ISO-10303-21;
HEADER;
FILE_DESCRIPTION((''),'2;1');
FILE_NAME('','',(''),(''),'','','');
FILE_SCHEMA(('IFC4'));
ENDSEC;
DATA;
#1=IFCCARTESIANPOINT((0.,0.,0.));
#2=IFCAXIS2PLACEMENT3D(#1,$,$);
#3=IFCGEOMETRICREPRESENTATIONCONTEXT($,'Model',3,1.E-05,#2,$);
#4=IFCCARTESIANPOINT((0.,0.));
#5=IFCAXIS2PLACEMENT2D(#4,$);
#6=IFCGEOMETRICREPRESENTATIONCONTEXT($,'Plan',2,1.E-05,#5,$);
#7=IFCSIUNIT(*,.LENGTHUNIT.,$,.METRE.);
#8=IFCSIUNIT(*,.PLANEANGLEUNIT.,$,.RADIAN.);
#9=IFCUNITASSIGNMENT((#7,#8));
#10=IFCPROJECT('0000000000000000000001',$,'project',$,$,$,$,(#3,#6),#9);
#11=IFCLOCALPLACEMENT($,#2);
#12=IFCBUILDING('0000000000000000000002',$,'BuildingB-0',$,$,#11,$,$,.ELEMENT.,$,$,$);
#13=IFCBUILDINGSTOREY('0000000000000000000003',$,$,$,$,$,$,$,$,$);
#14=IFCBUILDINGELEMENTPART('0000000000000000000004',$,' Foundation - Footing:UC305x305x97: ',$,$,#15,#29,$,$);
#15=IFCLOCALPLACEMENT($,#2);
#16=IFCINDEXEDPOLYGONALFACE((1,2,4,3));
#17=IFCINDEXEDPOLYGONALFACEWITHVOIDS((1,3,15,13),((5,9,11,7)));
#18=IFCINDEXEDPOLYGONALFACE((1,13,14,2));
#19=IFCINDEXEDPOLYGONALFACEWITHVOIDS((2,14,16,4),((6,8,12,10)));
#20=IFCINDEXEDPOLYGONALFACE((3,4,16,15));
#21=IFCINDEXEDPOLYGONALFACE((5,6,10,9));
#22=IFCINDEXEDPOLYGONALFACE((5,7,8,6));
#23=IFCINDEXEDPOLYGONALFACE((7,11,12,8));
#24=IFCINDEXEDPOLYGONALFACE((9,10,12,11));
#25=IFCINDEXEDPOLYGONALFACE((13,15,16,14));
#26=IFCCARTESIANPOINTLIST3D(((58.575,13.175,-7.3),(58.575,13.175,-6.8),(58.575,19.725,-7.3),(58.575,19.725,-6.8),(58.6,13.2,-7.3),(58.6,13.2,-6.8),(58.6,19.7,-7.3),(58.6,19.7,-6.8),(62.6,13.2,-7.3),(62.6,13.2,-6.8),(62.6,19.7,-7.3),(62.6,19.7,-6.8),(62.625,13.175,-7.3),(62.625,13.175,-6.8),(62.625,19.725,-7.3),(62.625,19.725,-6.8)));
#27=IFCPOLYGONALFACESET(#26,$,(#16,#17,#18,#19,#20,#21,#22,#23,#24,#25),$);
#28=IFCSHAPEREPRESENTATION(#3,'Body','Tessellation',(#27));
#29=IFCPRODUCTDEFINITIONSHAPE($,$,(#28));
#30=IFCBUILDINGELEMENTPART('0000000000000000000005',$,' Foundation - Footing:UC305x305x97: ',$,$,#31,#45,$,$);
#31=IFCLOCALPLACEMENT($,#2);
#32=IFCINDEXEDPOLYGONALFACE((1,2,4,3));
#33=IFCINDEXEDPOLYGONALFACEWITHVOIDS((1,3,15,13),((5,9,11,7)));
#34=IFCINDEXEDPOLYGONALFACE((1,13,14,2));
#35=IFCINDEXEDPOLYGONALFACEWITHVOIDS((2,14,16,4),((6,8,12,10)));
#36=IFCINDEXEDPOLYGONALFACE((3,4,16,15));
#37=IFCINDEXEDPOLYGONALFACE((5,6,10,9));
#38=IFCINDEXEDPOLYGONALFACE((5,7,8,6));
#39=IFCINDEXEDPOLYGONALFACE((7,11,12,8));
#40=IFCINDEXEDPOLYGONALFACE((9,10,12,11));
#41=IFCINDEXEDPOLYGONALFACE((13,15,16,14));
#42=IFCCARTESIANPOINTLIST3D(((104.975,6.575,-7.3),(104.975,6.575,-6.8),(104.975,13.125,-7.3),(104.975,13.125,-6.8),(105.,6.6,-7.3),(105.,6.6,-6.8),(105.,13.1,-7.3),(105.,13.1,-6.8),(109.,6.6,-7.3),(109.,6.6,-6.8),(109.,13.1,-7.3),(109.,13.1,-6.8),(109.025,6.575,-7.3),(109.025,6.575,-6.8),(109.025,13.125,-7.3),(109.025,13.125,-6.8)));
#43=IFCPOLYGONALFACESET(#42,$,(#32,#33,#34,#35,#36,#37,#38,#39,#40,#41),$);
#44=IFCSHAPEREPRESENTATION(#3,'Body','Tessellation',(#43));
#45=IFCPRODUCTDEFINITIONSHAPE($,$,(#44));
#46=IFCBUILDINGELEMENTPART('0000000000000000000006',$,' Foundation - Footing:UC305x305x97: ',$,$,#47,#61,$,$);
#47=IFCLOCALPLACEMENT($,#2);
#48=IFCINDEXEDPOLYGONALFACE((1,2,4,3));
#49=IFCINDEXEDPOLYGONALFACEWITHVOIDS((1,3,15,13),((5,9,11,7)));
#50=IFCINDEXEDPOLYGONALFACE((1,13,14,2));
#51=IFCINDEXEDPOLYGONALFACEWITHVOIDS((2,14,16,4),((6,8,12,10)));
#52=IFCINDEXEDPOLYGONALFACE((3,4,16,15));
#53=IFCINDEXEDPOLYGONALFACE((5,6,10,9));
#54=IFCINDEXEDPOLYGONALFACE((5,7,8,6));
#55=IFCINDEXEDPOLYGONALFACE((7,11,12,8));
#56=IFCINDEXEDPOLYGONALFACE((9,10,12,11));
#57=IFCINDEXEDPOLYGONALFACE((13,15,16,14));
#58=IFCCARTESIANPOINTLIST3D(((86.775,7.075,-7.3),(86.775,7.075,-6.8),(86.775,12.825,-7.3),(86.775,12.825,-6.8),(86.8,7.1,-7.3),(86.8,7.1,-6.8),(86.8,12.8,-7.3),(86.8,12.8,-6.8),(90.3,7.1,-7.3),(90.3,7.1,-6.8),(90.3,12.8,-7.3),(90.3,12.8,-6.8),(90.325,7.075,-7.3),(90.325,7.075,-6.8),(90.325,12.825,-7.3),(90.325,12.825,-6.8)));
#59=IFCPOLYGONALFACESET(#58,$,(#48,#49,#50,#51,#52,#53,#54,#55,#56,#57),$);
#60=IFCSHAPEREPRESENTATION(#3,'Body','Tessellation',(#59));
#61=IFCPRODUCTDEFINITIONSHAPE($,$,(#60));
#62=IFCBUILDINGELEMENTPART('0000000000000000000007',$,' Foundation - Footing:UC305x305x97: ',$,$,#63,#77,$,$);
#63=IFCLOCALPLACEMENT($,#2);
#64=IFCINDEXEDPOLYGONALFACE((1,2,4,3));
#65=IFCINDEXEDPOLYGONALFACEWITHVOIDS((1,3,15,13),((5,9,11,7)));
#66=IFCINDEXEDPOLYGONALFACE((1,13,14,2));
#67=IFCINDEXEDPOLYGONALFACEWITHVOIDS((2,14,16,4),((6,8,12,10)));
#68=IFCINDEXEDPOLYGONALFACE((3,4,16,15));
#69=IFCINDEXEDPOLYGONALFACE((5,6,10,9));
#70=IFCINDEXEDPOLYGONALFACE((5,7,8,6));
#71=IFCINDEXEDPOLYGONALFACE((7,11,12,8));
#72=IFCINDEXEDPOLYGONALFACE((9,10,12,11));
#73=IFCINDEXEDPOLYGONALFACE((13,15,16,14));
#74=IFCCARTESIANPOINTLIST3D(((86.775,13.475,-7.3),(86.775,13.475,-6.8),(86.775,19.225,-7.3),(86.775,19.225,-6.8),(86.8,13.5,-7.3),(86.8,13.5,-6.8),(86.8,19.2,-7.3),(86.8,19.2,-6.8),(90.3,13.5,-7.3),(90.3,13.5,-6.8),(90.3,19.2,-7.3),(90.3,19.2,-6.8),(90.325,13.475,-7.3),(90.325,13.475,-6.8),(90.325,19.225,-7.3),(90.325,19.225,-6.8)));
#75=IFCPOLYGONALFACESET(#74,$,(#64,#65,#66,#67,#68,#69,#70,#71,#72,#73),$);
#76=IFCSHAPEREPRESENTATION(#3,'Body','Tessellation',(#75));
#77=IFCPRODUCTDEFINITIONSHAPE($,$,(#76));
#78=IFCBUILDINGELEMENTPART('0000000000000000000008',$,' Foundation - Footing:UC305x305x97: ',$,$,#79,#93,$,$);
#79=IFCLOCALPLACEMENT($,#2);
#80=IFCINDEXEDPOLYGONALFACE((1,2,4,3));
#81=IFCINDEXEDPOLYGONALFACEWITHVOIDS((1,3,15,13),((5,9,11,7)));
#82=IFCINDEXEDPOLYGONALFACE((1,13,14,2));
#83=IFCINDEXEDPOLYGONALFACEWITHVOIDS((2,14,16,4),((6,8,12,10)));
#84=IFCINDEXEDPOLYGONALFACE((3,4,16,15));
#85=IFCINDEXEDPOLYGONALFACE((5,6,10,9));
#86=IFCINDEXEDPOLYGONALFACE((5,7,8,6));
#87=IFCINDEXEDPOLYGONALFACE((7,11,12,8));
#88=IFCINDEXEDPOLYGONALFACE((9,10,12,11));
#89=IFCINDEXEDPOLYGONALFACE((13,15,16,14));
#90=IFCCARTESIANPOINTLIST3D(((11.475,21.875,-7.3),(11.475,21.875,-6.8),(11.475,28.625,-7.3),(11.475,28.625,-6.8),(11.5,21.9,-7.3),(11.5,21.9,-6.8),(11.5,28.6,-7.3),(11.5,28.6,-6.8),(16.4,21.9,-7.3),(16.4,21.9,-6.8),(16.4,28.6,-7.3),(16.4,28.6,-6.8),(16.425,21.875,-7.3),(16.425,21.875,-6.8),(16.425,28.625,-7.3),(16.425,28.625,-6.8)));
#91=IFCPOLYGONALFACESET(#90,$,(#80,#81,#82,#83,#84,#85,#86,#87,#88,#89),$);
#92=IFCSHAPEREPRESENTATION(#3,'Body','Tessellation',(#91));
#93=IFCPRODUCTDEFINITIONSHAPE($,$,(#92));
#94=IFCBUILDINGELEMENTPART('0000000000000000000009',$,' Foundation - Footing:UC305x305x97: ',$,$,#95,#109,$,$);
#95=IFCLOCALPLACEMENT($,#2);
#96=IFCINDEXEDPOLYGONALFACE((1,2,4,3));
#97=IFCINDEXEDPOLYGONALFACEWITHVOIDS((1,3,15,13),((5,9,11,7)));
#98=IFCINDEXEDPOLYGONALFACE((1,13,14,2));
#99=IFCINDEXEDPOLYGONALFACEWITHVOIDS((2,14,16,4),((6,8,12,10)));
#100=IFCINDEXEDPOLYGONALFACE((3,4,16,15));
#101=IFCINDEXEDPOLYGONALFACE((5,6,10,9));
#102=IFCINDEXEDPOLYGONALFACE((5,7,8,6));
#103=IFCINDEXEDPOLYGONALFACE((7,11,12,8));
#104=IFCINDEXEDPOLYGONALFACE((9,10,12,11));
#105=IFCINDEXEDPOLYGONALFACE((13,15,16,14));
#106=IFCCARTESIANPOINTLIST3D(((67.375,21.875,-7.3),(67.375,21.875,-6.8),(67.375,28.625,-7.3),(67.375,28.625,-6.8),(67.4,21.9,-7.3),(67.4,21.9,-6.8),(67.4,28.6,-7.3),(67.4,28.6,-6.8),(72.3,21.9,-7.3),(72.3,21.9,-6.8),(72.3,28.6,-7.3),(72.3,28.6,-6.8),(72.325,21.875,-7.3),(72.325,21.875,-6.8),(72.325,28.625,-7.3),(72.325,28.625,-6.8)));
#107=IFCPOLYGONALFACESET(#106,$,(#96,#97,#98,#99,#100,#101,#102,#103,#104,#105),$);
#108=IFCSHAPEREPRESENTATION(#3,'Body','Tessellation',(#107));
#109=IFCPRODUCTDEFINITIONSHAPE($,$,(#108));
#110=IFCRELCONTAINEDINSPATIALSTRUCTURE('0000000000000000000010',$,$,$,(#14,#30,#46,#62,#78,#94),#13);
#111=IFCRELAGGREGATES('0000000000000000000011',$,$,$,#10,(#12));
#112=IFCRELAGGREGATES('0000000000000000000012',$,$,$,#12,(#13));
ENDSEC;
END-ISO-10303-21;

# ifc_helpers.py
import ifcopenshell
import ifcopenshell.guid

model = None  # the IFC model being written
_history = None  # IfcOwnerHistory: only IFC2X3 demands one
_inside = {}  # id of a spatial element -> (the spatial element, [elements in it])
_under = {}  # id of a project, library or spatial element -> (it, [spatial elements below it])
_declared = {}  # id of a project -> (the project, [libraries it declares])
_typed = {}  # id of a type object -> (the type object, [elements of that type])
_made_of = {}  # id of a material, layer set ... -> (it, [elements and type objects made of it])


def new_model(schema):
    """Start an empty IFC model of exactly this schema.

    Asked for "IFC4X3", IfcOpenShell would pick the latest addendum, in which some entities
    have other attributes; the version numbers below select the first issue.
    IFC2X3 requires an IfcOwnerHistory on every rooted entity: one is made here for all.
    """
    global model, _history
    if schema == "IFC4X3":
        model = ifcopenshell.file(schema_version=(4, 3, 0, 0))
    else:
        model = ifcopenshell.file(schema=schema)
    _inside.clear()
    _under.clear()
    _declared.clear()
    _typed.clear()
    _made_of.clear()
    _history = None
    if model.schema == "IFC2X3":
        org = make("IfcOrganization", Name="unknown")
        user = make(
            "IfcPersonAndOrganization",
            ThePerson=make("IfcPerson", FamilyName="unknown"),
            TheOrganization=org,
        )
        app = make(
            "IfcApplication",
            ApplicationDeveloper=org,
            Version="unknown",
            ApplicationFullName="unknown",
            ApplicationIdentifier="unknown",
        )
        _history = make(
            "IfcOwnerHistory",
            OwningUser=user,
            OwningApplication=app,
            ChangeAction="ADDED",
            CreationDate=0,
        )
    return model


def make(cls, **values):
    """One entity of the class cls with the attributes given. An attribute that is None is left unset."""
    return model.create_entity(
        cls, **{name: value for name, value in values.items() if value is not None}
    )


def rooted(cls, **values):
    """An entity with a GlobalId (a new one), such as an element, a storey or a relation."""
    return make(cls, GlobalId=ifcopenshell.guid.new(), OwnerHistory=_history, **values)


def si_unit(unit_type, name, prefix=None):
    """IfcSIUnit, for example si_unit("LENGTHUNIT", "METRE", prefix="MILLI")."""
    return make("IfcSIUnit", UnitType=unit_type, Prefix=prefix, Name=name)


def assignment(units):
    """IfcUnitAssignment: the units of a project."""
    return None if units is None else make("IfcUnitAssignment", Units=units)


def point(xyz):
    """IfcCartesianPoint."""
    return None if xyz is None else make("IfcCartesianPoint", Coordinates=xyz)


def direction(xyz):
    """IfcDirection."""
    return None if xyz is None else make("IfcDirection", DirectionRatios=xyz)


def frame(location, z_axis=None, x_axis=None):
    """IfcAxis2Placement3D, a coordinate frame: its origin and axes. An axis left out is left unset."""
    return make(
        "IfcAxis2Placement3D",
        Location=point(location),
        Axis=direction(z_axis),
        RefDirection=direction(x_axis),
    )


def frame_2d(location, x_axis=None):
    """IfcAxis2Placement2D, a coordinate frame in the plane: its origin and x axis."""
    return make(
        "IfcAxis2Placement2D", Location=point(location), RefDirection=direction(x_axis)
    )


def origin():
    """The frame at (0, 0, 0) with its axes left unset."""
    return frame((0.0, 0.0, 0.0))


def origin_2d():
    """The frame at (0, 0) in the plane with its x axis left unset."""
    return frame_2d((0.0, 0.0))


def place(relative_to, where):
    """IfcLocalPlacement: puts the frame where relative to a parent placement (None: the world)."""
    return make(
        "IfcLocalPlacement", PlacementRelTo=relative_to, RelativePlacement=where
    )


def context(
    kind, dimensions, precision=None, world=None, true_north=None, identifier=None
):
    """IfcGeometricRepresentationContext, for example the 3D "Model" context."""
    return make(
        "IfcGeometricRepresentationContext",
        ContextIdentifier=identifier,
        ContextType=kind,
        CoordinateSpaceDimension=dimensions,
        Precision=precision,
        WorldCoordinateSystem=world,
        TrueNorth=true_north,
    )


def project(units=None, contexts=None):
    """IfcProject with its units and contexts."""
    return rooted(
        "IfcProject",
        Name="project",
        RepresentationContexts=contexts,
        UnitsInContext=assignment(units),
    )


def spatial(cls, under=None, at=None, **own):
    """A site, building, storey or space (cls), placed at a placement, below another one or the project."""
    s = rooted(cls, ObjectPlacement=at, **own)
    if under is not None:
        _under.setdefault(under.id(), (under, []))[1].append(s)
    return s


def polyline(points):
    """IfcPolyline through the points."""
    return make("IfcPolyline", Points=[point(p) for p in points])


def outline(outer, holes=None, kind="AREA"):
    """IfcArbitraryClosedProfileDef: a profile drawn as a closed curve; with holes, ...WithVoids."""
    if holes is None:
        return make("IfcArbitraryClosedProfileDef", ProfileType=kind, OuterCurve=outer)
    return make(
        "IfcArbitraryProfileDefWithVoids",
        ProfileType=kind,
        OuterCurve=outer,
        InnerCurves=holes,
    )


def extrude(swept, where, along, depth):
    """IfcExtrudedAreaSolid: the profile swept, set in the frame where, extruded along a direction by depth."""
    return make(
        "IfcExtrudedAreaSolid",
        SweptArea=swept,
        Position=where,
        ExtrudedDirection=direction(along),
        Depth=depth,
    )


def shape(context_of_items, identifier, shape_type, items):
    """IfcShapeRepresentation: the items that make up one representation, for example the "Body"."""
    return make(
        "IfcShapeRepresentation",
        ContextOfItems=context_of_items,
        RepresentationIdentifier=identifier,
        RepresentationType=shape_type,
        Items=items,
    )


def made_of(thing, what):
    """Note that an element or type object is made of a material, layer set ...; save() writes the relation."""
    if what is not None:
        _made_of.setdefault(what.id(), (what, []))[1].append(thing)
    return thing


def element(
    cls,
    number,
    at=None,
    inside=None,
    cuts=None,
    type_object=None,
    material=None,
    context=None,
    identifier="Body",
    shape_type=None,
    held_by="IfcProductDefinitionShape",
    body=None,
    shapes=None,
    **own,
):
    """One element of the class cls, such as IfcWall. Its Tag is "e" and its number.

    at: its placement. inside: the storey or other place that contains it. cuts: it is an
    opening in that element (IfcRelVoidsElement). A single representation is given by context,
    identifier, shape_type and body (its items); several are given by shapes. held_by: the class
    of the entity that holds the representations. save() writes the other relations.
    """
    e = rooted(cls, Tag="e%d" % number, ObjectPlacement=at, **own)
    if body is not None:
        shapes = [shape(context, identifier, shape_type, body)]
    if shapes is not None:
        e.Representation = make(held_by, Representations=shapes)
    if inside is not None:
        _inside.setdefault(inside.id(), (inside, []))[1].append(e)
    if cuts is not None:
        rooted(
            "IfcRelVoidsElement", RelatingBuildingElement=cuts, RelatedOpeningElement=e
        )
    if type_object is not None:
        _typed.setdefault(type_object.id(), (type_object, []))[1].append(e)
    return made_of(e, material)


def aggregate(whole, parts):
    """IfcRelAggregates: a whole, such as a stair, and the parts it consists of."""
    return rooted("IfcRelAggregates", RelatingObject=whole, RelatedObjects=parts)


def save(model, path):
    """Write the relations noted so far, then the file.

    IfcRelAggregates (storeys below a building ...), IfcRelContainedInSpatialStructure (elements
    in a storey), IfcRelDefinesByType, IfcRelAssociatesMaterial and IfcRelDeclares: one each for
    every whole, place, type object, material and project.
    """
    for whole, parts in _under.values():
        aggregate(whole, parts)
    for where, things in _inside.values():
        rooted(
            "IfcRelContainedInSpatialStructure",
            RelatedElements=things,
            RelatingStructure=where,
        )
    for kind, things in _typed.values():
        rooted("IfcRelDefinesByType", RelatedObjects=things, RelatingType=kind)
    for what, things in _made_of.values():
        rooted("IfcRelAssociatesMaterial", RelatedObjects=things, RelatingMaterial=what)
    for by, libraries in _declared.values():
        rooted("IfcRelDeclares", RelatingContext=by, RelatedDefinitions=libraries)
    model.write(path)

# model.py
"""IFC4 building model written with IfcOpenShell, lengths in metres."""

from ifc_helpers import new_model, si_unit, origin, origin_2d, place, context, project, spatial, polyline, outline, extrude, element, save


model = new_model("IFC4")

# Units and contexts
model_context = context("Model", 3, precision=1e-05, world=origin())
plan_context = context("Plan", 2, precision=1e-05, world=origin_2d())
ifc_project = project(units=[si_unit("LENGTHUNIT", "METRE"), si_unit("PLANEANGLEUNIT", "RADIAN")], contexts=[model_context, plan_context])

# Building, storey
building_placement = place(None, origin())
building = spatial("IfcBuilding", under=ifc_project, at=building_placement, Name="BuildingB-0", CompositionType="ELEMENT")
storey = spatial("IfcBuildingStorey", under=building)

# Building element parts, openings
building_element_part_1 = element("IfcBuildingElementPart", 1, inside=storey, Name=" Foundation - Footing:UC305x305x97: ", context=model_context, shape_type="SweptSolid", body=[
    extrude(outline(polyline([(58.575, 19.725, -7.3), (62.625, 19.725, -7.3), (62.625, 13.175, -7.3), (58.575, 13.175, -7.3), (58.575, 19.725, -7.3)])), None, (0.0, 0.0, 1.0), 0.5),
])
element("IfcOpeningElement", 2, inside=storey, cuts=building_element_part_1, context=model_context, shape_type="SweptSolid", body=[
    extrude(outline(polyline([(58.6, 19.7, -7.3), (62.6, 19.7, -7.3), (62.6, 13.2, -7.3), (58.6, 13.2, -7.3), (58.6, 19.7, -7.3)])), None, (0.0, 0.0, 1.0), 0.5),
])
building_element_part_2 = element("IfcBuildingElementPart", 3, inside=storey, Name=" Foundation - Footing:UC305x305x97: ", context=model_context, shape_type="SweptSolid", body=[
    extrude(outline(polyline([(109.025, 13.125, -7.3), (104.975, 13.125, -7.3), (104.975, 6.575, -7.3), (109.025, 6.575, -7.3), (109.025, 13.125, -7.3)])), None, (0.0, 0.0, 1.0), 0.5),
])
element("IfcOpeningElement", 4, inside=storey, cuts=building_element_part_2, context=model_context, shape_type="SweptSolid", body=[
    extrude(outline(polyline([(109.0, 13.1, -7.3), (105.0, 13.1, -7.3), (105.0, 6.6, -7.3), (109.0, 6.6, -7.3), (109.0, 13.1, -7.3)])), None, (0.0, 0.0, 1.0), 0.5),
])
building_element_part_3 = element("IfcBuildingElementPart", 5, inside=storey, Name=" Foundation - Footing:UC305x305x97: ", context=model_context, shape_type="SweptSolid", body=[
    extrude(outline(polyline([(86.775, 12.825, -7.3), (90.325, 12.825, -7.3), (90.325, 7.075, -7.3), (86.775, 7.075, -7.3), (86.775, 12.825, -7.3)])), None, (0.0, 0.0, 1.0), 0.5),
])
element("IfcOpeningElement", 6, inside=storey, cuts=building_element_part_3, context=model_context, shape_type="SweptSolid", body=[
    extrude(outline(polyline([(86.8, 12.8, -7.3), (90.3, 12.8, -7.3), (90.3, 7.1, -7.3), (86.8, 7.1, -7.3), (86.8, 12.8, -7.3)])), None, (0.0, 0.0, 1.0), 0.5),
])
building_element_part_4 = element("IfcBuildingElementPart", 7, inside=storey, Name=" Foundation - Footing:UC305x305x97: ", context=model_context, shape_type="SweptSolid", body=[
    extrude(outline(polyline([(86.775, 19.225, -7.3), (90.325, 19.225, -7.3), (90.325, 13.475, -7.3), (86.775, 13.475, -7.3), (86.775, 19.225, -7.3)])), None, (0.0, 0.0, 1.0), 0.5),
])
element("IfcOpeningElement", 8, inside=storey, cuts=building_element_part_4, context=model_context, shape_type="SweptSolid", body=[
    extrude(outline(polyline([(86.8, 19.2, -7.3), (90.3, 19.2, -7.3), (90.3, 13.5, -7.3), (86.8, 13.5, -7.3), (86.8, 19.2, -7.3)])), None, (0.0, 0.0, 1.0), 0.5),
])
building_element_part_5 = element("IfcBuildingElementPart", 9, inside=storey, Name=" Foundation - Footing:UC305x305x97: ", context=model_context, shape_type="SweptSolid", body=[
    extrude(outline(polyline([(16.425, 21.875, -7.3), (16.425, 28.625, -7.3), (11.475, 28.625, -7.3), (11.475, 21.875, -7.3), (16.425, 21.875, -7.3)])), None, (0.0, 0.0, 1.0), 0.5),
])
element("IfcOpeningElement", 10, inside=storey, cuts=building_element_part_5, context=model_context, shape_type="SweptSolid", body=[
    extrude(outline(polyline([(16.4, 21.9, -7.3), (16.4, 28.6, -7.3), (11.5, 28.6, -7.3), (11.5, 21.9, -7.3), (16.4, 21.9, -7.3)])), None, (0.0, 0.0, 1.0), 0.5),
])
building_element_part_6 = element("IfcBuildingElementPart", 11, inside=storey, Name=" Foundation - Footing:UC305x305x97: ", context=model_context, shape_type="SweptSolid", body=[
    extrude(outline(polyline([(67.375, 21.875, -7.3), (67.375, 28.625, -7.3), (72.325, 28.625, -7.3), (72.325, 21.875, -7.3), (67.375, 21.875, -7.3)])), None, (0.0, 0.0, 1.0), 0.5),
])
element("IfcOpeningElement", 12, inside=storey, cuts=building_element_part_6, context=model_context, shape_type="SweptSolid", body=[
    extrude(outline(polyline([(67.4, 21.9, -7.3), (67.4, 28.6, -7.3), (72.3, 28.6, -7.3), (72.3, 21.9, -7.3), (67.4, 21.9, -7.3)])), None, (0.0, 0.0, 1.0), 0.5),
])

save(model, "model.ifc")
